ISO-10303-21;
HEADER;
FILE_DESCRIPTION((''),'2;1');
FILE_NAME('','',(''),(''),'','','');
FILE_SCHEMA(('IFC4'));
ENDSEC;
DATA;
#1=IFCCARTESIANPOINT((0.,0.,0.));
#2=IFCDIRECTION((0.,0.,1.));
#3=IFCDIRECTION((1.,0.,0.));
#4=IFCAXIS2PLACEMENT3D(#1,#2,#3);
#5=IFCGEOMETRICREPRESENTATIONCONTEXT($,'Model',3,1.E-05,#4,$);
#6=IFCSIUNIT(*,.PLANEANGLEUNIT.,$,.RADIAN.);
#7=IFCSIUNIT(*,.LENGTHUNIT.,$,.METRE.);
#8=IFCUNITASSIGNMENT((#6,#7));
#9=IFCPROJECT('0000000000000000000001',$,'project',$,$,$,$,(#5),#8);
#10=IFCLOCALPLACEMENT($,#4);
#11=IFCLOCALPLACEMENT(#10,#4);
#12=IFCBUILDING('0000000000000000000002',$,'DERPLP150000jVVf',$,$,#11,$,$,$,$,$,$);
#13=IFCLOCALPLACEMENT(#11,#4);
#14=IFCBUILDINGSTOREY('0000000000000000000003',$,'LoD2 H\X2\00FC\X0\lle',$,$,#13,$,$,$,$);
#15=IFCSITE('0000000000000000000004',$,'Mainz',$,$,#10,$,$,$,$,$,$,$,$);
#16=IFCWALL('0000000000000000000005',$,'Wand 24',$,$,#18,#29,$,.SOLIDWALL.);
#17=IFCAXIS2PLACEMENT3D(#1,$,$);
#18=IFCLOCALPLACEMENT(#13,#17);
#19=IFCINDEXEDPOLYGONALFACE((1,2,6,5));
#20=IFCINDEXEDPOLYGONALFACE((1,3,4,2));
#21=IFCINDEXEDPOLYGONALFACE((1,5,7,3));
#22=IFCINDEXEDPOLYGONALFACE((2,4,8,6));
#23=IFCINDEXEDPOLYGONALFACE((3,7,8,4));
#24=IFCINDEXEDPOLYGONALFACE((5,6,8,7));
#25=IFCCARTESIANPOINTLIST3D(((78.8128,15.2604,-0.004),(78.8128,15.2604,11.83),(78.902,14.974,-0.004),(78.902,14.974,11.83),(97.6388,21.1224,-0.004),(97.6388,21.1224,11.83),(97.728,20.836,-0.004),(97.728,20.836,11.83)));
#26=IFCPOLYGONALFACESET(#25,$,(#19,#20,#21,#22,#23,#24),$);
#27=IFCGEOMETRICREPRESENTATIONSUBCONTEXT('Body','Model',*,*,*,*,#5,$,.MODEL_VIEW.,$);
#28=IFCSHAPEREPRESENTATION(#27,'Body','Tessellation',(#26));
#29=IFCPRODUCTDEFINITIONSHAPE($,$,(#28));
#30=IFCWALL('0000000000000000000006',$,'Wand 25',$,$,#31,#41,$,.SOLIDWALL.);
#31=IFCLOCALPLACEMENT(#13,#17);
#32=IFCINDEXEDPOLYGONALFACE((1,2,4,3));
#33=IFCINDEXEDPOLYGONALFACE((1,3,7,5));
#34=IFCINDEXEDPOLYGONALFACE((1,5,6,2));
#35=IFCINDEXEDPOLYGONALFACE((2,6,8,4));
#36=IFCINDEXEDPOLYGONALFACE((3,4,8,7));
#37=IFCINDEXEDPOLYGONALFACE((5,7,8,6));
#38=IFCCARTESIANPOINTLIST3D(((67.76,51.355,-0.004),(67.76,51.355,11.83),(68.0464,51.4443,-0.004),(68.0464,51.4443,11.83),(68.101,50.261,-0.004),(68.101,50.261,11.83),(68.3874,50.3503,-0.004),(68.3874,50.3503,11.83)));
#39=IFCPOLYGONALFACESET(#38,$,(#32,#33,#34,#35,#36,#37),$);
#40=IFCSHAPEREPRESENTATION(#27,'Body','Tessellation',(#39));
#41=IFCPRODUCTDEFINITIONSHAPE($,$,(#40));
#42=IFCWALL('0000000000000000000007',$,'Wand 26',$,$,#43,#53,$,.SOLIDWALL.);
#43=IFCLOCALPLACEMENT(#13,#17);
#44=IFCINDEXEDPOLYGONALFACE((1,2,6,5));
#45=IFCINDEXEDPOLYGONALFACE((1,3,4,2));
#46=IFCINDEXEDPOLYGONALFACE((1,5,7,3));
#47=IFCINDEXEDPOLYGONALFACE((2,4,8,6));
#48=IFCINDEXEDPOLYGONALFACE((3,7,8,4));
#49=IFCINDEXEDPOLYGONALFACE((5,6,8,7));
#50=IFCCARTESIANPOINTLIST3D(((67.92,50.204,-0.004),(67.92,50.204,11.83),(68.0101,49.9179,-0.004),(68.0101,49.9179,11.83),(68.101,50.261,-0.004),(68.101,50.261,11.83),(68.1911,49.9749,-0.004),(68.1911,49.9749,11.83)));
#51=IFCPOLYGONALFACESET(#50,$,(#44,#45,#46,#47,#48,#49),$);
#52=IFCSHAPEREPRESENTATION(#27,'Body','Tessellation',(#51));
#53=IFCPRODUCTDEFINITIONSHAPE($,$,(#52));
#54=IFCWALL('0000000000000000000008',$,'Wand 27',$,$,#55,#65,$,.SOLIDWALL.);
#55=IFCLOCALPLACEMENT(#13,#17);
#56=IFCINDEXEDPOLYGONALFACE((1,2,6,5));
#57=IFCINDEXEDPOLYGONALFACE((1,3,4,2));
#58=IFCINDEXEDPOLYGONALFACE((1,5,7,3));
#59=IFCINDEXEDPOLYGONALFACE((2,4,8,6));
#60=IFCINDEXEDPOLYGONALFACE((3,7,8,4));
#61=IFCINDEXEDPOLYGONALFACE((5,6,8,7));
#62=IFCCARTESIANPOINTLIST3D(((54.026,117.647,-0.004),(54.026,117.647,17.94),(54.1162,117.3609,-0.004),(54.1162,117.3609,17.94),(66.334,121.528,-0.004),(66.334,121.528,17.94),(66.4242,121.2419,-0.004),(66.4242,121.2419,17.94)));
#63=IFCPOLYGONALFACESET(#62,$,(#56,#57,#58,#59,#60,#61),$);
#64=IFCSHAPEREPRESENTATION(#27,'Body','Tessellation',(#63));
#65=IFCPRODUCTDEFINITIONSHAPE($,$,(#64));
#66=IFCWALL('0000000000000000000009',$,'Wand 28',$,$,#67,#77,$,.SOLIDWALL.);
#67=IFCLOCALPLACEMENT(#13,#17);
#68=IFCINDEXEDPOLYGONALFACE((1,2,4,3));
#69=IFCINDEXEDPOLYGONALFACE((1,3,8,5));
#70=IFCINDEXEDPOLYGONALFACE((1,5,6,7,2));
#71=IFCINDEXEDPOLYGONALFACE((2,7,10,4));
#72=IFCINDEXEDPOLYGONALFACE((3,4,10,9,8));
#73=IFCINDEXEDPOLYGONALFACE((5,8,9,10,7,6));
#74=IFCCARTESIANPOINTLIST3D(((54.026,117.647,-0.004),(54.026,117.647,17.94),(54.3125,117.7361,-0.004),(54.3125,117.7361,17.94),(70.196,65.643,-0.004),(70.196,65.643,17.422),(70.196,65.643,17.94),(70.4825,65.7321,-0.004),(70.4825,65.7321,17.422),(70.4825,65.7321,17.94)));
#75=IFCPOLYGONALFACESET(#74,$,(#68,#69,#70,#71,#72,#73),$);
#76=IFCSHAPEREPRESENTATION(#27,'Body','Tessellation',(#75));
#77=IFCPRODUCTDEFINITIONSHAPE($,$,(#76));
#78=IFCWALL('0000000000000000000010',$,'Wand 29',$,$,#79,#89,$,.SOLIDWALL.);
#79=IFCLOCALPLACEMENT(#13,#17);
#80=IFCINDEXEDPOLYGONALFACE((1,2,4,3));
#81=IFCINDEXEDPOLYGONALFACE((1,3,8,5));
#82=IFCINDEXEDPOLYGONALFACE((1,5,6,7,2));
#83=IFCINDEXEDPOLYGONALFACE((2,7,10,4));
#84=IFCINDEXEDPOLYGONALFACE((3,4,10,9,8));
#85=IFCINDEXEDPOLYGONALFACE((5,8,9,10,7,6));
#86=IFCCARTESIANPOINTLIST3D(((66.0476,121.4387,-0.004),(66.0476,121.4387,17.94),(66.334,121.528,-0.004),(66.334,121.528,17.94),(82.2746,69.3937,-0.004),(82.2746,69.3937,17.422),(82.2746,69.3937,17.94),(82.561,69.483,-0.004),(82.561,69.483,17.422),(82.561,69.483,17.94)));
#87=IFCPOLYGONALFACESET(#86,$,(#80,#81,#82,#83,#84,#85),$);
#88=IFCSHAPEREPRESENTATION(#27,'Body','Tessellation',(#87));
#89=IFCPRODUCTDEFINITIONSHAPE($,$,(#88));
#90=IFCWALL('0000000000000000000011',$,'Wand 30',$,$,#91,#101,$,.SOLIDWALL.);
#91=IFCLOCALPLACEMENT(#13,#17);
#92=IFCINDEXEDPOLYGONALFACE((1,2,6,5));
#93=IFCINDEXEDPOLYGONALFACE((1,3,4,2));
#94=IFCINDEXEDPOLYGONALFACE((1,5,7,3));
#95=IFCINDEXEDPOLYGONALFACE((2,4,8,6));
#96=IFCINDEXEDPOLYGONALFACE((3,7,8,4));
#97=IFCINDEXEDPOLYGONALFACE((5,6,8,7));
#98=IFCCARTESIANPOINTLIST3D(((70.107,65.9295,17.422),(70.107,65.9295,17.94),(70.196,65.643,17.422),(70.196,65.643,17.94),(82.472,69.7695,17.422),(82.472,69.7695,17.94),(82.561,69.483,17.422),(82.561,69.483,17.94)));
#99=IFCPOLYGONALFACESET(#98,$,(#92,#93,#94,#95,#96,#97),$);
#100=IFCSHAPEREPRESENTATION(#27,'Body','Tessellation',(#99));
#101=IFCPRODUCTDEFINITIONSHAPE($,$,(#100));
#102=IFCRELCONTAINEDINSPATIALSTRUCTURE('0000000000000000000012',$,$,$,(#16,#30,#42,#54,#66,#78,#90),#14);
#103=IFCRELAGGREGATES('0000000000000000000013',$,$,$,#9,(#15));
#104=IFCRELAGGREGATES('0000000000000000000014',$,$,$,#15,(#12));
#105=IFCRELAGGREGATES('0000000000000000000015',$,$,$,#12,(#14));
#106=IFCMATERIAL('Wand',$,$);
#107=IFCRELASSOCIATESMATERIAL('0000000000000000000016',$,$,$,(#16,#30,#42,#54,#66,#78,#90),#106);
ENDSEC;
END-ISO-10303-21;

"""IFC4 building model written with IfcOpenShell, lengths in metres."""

from ifc_helpers import new_model, si_unit, frame, origin_with_axes, place, context, subcontext, project, spatial, polyline, outline, extrude, material, element, save


model = new_model("IFC4")

# Units and contexts
model_context = context("Model", 3, precision=1e-05, world=origin_with_axes())
body_context = subcontext(model_context, "Body", "Model", "MODEL_VIEW")
ifc_project = project(units=[si_unit("PLANEANGLEUNIT", "RADIAN"), si_unit("LENGTHUNIT", "METRE")], contexts=[model_context])

# Site, building, storey
site_placement = place(None, origin_with_axes())
site = spatial("IfcSite", under=ifc_project, at=site_placement, Name="Mainz")
building_placement = place(site_placement, origin_with_axes())
building = spatial("IfcBuilding", under=site, at=building_placement, Name="DERPLP150000jVVf")
storey_placement = place(building_placement, origin_with_axes())
storey = spatial("IfcBuildingStorey", under=building, at=storey_placement, Name="LoD2 Hülle")

# Walls
ifc_material_1 = material(Name="Wand")
wall_1_placement = place(storey_placement, origin_with_axes())
element("IfcWall", 1, at=wall_1_placement, inside=storey, material=ifc_material_1, Name="Wand 24", PredefinedType="SOLIDWALL", context=body_context, shape_type="SweptSolid", body=[
    extrude(outline(polyline([(0.0, 0.0), (19.7175, 0.0), (19.7175, 11.834), (0.0, 11.834), (0.0, 0.0)])), frame((97.728, 20.836, 11.83), z_axis=(0.297299, -0.954784, 0.0), x_axis=(-0.954784, -0.297299, 0.0)), (0.0, 0.0, -1.0), 0.3),
])
wall_2_placement = place(storey_placement, origin_with_axes())
element("IfcWall", 2, at=wall_2_placement, inside=storey, material=ifc_material_1, Name="Wand 25", PredefinedType="SOLIDWALL", context=body_context, shape_type="SweptSolid", body=[
    extrude(outline(polyline([(0.0, 0.0), (1.1459, 0.0), (1.1459, 11.834), (0.0, 11.834), (0.0, 0.0)])), frame((68.101, 50.261, 11.83), z_axis=(-0.954697, -0.297579, 0.0), x_axis=(-0.297579, 0.954697, 0.0)), (0.0, 0.0, -1.0), 0.3),
])
wall_3_placement = place(storey_placement, origin_with_axes())
element("IfcWall", 3, at=wall_3_placement, inside=storey, material=ifc_material_1, Name="Wand 26", PredefinedType="SOLIDWALL", context=body_context, shape_type="SweptSolid", body=[
    extrude(outline(polyline([(0.0, 0.0), (0.1898, 0.0), (0.1898, 11.834), (0.0, 11.834), (0.0, 0.0)])), frame((67.92, 50.204, 11.83), z_axis=(-0.300375, 0.953821, 0.0), x_axis=(0.953821, 0.300375, 0.0)), (0.0, 0.0, -1.0), 0.3),
])
wall_4_placement = place(storey_placement, origin_with_axes())
element("IfcWall", 4, at=wall_4_placement, inside=storey, material=ifc_material_1, Name="Wand 27", PredefinedType="SOLIDWALL", context=body_context, shape_type="SweptSolid", body=[
    extrude(outline(polyline([(0.0, 0.0), (12.9054, 0.0), (12.9054, 17.944), (0.0, 17.944), (0.0, 0.0)])), frame((54.026, 117.647, 17.94), z_axis=(-0.300727, 0.95371, 0.0), x_axis=(0.95371, 0.300727, 0.0)), (0.0, 0.0, -1.0), 0.3),
])
wall_5_placement = place(storey_placement, origin_with_axes())
element("IfcWall", 5, at=wall_5_placement, inside=storey, material=ifc_material_1, Name="Wand 28", PredefinedType="SOLIDWALL", context=body_context, shape_type="SweptSolid", body=[
    extrude(outline(polyline([(0.0, 0.0), (54.4599, 0.0), (54.4599, 17.944), (0.0, 17.944), (0.0, 0.518), (0.0, 0.0)])), frame((70.196, 65.643, 17.94), z_axis=(-0.954904, -0.296916, 0.0), x_axis=(-0.296916, 0.954904, 0.0)), (0.0, 0.0, -1.0), 0.3),
])
wall_6_placement = place(storey_placement, origin_with_axes())
element("IfcWall", 6, at=wall_6_placement, inside=storey, material=ifc_material_1, Name="Wand 29", PredefinedType="SOLIDWALL", context=body_context, shape_type="SweptSolid", body=[
    extrude(outline(polyline([(0.0, 0.0), (54.516, 0.0), (54.516, 0.518), (54.516, 17.944), (0.0, 17.944), (0.0, 0.0)])), frame((66.334, 121.528, 17.94), z_axis=(0.954673, 0.297656, 0.0), x_axis=(0.297656, -0.954673, 0.0)), (0.0, 0.0, -1.0), 0.3),
])
wall_7_placement = place(storey_placement, origin_with_axes())
element("IfcWall", 7, at=wall_7_placement, inside=storey, material=ifc_material_1, Name="Wand 30", PredefinedType="SOLIDWALL", context=body_context, shape_type="SweptSolid", body=[
    extrude(outline(polyline([(0.0, 0.0), (12.9475, 0.0), (12.9475, 0.518), (0.0, 0.518), (0.0, 0.0)])), frame((70.196, 65.643, 17.422), z_axis=(0.296581, -0.955008, 0.0), x_axis=(0.955008, 0.296581, 0.0)), (0.0, 0.0, -1.0), 0.3),
])

save(model, "model.ifc")
